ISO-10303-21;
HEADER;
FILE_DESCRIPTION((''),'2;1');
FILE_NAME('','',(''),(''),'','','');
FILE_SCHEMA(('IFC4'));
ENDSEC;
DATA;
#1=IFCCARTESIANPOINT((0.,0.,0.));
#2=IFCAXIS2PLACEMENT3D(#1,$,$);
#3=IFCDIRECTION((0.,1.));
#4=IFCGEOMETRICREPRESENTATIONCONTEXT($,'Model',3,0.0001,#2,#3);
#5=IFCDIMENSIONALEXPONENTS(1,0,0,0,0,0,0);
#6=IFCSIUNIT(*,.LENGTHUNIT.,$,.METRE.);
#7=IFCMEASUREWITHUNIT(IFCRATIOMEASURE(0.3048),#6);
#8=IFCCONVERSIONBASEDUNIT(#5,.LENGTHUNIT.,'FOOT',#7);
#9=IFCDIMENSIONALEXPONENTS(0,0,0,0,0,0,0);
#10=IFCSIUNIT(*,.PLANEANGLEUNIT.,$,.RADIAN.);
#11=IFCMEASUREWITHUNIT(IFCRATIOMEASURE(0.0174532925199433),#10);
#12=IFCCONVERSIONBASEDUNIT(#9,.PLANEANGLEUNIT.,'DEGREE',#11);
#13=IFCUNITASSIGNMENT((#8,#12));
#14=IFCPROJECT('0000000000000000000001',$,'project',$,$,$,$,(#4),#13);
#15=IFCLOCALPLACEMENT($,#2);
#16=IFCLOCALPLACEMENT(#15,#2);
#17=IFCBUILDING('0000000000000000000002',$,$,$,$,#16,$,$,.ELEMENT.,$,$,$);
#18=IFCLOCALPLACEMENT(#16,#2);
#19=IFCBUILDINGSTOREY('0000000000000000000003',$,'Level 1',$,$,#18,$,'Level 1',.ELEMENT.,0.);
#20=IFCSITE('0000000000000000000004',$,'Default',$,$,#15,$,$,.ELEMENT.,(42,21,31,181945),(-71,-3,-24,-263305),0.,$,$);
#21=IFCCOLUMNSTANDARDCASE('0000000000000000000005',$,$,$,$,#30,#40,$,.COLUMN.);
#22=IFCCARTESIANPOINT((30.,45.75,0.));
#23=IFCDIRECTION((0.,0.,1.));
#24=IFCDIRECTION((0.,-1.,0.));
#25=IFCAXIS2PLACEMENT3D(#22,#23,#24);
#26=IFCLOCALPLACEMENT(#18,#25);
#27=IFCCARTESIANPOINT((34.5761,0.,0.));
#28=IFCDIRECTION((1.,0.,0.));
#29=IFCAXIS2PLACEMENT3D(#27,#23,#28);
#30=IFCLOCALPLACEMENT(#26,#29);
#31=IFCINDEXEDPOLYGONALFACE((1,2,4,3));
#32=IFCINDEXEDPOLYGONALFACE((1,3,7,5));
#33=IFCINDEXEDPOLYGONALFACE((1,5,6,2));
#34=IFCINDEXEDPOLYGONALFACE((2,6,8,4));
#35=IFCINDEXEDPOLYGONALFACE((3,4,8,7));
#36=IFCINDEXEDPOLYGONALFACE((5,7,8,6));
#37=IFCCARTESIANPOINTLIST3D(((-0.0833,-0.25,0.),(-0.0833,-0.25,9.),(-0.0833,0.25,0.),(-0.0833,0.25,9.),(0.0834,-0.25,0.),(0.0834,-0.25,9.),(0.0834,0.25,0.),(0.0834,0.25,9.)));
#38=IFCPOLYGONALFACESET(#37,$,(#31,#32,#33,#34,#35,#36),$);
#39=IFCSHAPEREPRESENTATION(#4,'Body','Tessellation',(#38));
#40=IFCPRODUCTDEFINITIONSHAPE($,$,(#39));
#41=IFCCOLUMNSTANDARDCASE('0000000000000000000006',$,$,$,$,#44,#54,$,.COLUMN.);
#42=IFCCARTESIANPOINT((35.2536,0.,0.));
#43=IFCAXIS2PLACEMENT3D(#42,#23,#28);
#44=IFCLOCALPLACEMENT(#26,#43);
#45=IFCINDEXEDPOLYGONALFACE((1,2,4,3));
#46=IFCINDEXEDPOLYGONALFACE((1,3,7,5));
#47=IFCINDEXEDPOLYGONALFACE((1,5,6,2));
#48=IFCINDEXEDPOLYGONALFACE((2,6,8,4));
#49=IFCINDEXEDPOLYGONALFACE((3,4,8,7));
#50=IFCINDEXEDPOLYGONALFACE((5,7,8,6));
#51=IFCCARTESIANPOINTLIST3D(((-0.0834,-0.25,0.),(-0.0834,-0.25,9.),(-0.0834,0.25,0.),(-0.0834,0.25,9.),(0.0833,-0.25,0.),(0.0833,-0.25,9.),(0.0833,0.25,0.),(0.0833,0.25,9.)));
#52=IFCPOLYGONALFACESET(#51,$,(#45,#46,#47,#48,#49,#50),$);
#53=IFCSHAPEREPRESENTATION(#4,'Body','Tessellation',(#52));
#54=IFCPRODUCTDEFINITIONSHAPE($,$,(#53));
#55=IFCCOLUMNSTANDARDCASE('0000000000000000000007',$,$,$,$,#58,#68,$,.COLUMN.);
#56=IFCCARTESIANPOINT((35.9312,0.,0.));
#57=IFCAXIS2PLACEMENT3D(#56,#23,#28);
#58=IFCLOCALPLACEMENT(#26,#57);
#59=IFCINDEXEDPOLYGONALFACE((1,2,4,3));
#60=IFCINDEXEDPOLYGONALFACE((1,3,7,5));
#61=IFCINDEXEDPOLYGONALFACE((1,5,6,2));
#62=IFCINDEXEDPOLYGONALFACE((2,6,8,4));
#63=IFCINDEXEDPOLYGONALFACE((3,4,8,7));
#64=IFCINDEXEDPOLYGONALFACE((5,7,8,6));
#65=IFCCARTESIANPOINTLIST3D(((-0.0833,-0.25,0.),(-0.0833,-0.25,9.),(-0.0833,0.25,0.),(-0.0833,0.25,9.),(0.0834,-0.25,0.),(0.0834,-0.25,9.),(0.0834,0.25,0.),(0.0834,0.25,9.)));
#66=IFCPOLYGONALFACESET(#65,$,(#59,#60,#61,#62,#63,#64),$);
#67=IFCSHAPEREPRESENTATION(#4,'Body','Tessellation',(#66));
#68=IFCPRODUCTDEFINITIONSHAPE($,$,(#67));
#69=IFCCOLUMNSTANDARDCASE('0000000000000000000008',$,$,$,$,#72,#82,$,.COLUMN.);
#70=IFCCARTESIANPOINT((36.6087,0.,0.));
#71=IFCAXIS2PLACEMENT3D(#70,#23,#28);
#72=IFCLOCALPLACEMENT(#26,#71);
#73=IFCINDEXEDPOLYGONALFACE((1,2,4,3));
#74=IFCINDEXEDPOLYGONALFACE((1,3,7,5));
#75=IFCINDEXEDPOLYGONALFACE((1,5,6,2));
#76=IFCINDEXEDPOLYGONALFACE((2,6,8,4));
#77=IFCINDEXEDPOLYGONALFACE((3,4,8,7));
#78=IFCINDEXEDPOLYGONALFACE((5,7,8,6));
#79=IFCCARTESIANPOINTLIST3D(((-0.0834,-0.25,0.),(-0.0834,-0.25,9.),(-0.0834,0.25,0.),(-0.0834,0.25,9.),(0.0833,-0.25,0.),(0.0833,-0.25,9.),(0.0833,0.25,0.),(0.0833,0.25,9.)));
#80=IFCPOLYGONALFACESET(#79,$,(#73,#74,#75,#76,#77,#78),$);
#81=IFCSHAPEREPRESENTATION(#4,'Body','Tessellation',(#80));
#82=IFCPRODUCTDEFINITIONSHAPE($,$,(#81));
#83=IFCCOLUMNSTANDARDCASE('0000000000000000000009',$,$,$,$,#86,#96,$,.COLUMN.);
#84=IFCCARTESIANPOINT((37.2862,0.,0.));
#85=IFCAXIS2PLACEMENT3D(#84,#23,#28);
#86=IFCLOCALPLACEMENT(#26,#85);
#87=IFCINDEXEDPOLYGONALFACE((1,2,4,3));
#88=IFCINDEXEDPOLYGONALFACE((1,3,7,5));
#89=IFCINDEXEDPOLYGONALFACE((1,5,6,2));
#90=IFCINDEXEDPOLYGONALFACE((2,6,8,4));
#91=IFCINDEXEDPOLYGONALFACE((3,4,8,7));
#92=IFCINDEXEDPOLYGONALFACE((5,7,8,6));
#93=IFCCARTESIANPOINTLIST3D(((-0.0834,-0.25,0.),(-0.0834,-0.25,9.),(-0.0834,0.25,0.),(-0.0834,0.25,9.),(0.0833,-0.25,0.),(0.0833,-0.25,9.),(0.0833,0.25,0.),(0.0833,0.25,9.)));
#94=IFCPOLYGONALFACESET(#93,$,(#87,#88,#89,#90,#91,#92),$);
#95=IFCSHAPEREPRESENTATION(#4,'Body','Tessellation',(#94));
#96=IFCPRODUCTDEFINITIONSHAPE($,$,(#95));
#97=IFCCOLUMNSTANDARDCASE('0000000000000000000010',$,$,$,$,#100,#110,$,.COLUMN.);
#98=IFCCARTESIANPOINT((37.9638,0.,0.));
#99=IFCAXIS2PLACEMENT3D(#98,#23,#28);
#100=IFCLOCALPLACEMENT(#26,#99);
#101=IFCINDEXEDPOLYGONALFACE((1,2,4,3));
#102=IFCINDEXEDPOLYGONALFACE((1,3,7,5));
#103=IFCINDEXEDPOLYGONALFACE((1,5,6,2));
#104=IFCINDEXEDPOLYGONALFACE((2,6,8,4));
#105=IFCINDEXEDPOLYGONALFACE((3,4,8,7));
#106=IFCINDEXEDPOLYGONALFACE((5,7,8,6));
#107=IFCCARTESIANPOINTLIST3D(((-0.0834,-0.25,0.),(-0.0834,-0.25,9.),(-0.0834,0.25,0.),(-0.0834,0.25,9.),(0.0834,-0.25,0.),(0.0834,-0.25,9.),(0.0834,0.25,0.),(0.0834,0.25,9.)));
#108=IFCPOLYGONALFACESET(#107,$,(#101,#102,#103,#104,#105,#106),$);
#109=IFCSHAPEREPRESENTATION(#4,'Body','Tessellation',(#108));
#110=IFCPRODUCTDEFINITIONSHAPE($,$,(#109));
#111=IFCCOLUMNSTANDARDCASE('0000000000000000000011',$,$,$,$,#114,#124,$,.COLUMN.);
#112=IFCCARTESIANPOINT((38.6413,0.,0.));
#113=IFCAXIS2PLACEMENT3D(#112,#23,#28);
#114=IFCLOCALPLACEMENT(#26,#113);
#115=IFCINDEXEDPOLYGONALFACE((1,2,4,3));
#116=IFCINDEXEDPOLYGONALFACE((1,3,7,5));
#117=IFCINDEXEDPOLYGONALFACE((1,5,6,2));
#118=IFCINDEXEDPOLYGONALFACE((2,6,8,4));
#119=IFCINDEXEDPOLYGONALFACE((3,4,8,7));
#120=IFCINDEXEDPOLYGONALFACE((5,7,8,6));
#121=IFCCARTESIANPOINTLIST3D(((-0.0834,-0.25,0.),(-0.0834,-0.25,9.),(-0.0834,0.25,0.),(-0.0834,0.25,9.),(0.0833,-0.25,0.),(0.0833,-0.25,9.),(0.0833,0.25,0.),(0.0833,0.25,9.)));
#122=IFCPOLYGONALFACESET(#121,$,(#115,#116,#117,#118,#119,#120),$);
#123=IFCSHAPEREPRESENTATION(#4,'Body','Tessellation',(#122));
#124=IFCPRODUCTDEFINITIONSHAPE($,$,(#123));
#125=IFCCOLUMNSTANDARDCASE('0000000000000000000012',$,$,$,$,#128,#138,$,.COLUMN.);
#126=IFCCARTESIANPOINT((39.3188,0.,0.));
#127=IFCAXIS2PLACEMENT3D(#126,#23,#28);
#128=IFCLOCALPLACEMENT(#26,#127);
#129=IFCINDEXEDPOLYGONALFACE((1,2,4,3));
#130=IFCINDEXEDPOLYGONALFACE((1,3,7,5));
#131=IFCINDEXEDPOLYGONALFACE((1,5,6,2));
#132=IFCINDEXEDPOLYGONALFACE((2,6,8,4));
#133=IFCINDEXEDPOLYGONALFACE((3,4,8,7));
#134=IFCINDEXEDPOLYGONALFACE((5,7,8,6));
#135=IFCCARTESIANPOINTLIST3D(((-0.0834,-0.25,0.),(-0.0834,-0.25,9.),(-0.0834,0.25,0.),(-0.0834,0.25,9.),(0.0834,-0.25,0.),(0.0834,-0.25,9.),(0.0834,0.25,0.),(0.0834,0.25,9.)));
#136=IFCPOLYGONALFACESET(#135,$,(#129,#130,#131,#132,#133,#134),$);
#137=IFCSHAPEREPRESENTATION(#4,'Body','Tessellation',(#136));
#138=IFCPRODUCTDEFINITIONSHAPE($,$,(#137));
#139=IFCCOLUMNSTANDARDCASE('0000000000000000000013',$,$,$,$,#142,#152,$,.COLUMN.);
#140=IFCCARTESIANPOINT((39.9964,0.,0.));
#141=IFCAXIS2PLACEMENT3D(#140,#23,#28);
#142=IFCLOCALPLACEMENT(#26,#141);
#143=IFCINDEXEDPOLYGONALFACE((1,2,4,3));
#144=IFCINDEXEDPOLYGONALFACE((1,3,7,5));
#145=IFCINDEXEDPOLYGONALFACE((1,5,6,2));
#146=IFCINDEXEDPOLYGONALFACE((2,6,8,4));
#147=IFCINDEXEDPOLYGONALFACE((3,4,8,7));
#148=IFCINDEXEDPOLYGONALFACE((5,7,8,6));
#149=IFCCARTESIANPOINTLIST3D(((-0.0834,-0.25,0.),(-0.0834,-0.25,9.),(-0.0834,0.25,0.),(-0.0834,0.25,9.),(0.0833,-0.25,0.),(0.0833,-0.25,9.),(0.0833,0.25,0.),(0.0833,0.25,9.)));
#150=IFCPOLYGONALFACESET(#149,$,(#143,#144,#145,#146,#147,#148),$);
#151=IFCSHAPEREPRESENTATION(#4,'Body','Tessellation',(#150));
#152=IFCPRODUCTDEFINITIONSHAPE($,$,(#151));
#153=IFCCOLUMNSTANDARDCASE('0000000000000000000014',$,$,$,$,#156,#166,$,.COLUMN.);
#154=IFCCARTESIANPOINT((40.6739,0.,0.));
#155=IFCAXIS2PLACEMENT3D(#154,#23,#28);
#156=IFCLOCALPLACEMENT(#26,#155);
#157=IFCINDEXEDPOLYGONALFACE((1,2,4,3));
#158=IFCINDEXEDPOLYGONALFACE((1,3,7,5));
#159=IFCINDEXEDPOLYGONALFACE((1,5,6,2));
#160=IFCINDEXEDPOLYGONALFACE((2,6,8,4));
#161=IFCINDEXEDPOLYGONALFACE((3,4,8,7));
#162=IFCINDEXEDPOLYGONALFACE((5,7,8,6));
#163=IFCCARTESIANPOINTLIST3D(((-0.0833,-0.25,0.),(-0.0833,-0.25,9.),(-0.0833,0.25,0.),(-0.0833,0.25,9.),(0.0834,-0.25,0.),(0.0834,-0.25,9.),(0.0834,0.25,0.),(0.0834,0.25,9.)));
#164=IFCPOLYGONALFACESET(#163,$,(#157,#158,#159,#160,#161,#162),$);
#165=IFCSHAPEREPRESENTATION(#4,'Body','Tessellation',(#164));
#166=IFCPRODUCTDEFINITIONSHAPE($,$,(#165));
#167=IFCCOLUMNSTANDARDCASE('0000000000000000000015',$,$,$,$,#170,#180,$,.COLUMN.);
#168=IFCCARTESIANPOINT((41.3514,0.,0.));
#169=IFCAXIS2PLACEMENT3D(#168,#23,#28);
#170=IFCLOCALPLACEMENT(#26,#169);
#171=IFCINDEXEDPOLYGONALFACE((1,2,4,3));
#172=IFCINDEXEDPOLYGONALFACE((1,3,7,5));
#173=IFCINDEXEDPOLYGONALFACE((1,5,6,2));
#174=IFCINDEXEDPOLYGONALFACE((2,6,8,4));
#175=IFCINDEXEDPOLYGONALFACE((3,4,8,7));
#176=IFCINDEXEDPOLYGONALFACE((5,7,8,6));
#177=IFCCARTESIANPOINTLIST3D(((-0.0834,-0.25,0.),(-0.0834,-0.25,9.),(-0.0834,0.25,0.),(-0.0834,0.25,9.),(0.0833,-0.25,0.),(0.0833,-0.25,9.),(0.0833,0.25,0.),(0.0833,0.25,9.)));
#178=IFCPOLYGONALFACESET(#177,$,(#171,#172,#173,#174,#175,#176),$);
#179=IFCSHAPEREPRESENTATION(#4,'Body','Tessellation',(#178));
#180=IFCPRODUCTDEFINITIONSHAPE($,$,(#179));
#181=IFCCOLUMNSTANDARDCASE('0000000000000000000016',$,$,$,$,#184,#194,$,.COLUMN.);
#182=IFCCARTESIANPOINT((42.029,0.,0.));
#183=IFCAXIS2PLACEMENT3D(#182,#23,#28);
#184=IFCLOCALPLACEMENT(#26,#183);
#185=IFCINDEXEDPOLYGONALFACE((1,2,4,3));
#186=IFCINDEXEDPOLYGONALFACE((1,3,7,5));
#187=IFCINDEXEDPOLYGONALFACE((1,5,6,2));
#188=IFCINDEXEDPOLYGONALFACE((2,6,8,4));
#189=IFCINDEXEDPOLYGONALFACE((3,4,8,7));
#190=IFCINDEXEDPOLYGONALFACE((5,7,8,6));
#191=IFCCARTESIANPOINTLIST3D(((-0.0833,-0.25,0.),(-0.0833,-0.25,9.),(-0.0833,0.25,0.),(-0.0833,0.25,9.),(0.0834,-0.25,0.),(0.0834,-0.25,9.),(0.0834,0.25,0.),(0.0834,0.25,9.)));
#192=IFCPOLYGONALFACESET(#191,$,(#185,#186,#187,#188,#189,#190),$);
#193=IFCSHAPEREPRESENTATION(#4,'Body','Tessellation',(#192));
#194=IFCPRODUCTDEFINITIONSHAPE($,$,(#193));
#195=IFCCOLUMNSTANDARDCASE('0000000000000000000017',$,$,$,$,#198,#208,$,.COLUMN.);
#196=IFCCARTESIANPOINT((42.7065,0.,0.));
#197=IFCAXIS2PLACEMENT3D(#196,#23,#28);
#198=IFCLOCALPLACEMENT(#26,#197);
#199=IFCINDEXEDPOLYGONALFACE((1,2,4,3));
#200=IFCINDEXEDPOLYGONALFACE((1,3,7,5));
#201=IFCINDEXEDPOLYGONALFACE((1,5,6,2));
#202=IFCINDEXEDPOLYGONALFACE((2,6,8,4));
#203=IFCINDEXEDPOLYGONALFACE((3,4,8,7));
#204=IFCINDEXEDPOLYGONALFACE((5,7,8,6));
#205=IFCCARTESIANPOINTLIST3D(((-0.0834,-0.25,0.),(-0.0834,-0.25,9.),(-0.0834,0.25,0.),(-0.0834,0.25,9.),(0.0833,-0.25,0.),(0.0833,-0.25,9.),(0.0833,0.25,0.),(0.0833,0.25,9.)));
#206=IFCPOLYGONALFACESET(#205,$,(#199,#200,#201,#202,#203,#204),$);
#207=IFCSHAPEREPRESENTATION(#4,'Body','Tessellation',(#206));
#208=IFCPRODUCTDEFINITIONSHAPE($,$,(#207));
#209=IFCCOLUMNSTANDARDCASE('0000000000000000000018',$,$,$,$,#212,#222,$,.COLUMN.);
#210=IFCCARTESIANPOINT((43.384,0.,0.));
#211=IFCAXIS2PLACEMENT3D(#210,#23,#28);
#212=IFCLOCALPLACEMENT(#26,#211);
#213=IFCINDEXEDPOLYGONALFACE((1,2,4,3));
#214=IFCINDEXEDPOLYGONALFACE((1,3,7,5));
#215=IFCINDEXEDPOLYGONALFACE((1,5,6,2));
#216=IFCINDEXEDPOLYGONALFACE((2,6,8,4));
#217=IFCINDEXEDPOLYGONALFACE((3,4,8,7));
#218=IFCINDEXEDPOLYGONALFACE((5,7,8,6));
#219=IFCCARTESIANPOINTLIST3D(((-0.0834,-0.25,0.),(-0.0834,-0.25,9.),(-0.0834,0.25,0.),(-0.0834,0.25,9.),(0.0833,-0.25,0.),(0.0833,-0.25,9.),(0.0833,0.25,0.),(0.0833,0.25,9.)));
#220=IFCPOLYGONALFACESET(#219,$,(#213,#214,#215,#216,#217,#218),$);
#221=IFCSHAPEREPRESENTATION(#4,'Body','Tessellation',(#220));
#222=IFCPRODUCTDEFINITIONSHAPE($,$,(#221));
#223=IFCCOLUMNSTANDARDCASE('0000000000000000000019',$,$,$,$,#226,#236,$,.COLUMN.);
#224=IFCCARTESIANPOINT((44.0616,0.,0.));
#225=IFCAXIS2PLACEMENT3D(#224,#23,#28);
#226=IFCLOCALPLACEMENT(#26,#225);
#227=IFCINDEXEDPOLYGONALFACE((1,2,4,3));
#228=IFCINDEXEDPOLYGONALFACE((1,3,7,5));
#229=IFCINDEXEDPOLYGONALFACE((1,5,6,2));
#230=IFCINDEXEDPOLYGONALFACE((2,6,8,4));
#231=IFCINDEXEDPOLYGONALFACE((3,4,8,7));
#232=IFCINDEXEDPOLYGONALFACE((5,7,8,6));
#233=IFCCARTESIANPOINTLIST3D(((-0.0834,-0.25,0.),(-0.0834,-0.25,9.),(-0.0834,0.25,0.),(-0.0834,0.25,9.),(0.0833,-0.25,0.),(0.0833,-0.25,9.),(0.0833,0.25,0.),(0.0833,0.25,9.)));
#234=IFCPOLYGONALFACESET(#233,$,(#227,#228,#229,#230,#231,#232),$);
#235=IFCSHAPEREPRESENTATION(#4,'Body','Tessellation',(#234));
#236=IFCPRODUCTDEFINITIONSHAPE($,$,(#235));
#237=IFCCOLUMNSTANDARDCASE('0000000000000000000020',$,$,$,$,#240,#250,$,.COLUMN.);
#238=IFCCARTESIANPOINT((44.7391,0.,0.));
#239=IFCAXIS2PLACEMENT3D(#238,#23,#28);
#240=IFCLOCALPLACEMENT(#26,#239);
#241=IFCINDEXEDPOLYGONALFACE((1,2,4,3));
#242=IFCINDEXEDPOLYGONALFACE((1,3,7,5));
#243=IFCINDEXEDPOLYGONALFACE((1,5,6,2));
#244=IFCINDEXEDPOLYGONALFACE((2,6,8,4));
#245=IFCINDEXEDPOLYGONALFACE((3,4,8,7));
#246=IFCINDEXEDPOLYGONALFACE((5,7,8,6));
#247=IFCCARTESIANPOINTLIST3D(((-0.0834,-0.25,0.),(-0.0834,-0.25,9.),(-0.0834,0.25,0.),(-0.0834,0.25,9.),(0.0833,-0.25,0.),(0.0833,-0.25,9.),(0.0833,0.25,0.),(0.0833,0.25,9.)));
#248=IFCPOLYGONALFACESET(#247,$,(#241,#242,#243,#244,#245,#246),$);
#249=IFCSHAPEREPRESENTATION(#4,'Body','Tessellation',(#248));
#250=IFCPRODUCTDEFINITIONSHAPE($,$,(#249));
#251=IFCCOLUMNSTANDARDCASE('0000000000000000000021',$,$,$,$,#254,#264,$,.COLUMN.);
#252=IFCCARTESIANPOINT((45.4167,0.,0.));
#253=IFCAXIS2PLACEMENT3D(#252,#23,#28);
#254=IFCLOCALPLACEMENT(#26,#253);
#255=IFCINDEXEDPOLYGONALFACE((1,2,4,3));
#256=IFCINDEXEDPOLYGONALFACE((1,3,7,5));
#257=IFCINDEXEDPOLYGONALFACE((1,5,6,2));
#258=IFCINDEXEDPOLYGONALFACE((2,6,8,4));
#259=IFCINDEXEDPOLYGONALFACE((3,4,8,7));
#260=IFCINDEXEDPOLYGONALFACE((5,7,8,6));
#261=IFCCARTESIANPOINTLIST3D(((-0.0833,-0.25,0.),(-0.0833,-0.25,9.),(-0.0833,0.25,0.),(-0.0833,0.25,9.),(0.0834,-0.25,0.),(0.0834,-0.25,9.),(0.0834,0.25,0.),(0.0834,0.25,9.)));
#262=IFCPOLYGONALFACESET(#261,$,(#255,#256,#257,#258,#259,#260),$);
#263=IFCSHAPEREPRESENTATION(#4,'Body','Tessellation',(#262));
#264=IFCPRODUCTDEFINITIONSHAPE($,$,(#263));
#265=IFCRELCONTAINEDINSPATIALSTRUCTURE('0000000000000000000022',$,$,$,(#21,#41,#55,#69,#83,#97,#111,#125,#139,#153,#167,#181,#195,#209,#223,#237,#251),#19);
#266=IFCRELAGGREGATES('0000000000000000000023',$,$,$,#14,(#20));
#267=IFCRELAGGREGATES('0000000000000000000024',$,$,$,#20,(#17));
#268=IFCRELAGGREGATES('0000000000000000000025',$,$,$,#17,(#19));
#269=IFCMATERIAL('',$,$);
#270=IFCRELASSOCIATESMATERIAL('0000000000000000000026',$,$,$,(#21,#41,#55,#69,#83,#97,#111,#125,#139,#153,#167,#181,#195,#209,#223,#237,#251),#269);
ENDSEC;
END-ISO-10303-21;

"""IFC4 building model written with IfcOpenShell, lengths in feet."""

from ifc_helpers import new_model, entity, si_unit, converted_unit, direction, frame, origin, place, context, project, spatial, rectangle, extrude, material, element, save


model = new_model("IFC4")

# Units and contexts
model_context = context("Model", 3, precision=0.0001, world=origin(), true_north=direction((0.0, 1.0)))
ifc_project = project(units=[converted_unit("LENGTHUNIT", "FOOT", entity("IfcRatioMeasure", 0.3048), si_unit("LENGTHUNIT", "METRE"), dimensions=[1, 0, 0, 0, 0, 0, 0]), converted_unit("PLANEANGLEUNIT", "DEGREE", entity("IfcRatioMeasure", 0.0174532925199433), si_unit("PLANEANGLEUNIT", "RADIAN"), dimensions=[0, 0, 0, 0, 0, 0, 0])], contexts=[model_context])

# Site, building, storey
site_placement = place(None, origin())
site = spatial("IfcSite", under=ifc_project, at=site_placement, Name="Default", CompositionType="ELEMENT", RefLatitude=(42, 21, 31, 181945), RefLongitude=(-71, -3, -24, -263305), RefElevation=0.0)
building_placement = place(site_placement, origin())
building = spatial("IfcBuilding", under=site, at=building_placement, CompositionType="ELEMENT")
storey_placement = place(building_placement, origin())
storey = spatial("IfcBuildingStorey", under=building, at=storey_placement, Name="Level 1", LongName="Level 1", CompositionType="ELEMENT", Elevation=0.0)

# Columns
ifc_material = material(Name="")
placement_1 = place(storey_placement, frame((30.0, 45.75, 0.0), z_axis=(0.0, 0.0, 1.0), x_axis=(0.0, -1.0, 0.0)))
for number, where, z_axis, x_axis in (
    (1, (34.5761, 0.0, 0.0), (0.0, 0.0, 1.0), (1.0, 0.0, 0.0)),
    (2, (35.2536, 0.0, 0.0), (0.0, 0.0, 1.0), (1.0, 0.0, 0.0)),
    (3, (35.9312, 0.0, 0.0), (0.0, 0.0, 1.0), (1.0, 0.0, 0.0)),
    (4, (36.6087, 0.0, 0.0), (0.0, 0.0, 1.0), (1.0, 0.0, 0.0)),
    (5, (37.2862, 0.0, 0.0), (0.0, 0.0, 1.0), (1.0, 0.0, 0.0)),
    (6, (37.9638, 0.0, 0.0), (0.0, 0.0, 1.0), (1.0, 0.0, 0.0)),
    (7, (38.6413, 0.0, 0.0), (0.0, 0.0, 1.0), (1.0, 0.0, 0.0)),
    (8, (39.3188, 0.0, 0.0), (0.0, 0.0, 1.0), (1.0, 0.0, 0.0)),
    (9, (39.9964, 0.0, 0.0), (0.0, 0.0, 1.0), (1.0, 0.0, 0.0)),
    (10, (40.6739, 0.0, 0.0), (0.0, 0.0, 1.0), (1.0, 0.0, 0.0)),
    (11, (41.3514, 0.0, 0.0), (0.0, 0.0, 1.0), (1.0, 0.0, 0.0)),
    (12, (42.029, 0.0, 0.0), (0.0, 0.0, 1.0), (1.0, 0.0, 0.0)),
    (13, (42.7065, 0.0, 0.0), (0.0, 0.0, 1.0), (1.0, 0.0, 0.0)),
    (14, (43.384, 0.0, 0.0), (0.0, 0.0, 1.0), (1.0, 0.0, 0.0)),
    (15, (44.0616, 0.0, 0.0), (0.0, 0.0, 1.0), (1.0, 0.0, 0.0)),
    (16, (44.7391, 0.0, 0.0), (0.0, 0.0, 1.0), (1.0, 0.0, 0.0)),
    (17, (45.4167, 0.0, 0.0), (0.0, 0.0, 1.0), (1.0, 0.0, 0.0)),
):
    element("IfcColumnStandardCase", number, at=place(placement_1, frame(where, z_axis=z_axis, x_axis=x_axis)), inside=storey, material=ifc_material, PredefinedType="COLUMN", context=model_context, shape_type="SweptSolid", body=[
        extrude(rectangle(XDim=0.1667, YDim=0.5), origin(), (0.0, 0.0, 1.0), 9.0),
    ])

save(model, "model.ifc")
